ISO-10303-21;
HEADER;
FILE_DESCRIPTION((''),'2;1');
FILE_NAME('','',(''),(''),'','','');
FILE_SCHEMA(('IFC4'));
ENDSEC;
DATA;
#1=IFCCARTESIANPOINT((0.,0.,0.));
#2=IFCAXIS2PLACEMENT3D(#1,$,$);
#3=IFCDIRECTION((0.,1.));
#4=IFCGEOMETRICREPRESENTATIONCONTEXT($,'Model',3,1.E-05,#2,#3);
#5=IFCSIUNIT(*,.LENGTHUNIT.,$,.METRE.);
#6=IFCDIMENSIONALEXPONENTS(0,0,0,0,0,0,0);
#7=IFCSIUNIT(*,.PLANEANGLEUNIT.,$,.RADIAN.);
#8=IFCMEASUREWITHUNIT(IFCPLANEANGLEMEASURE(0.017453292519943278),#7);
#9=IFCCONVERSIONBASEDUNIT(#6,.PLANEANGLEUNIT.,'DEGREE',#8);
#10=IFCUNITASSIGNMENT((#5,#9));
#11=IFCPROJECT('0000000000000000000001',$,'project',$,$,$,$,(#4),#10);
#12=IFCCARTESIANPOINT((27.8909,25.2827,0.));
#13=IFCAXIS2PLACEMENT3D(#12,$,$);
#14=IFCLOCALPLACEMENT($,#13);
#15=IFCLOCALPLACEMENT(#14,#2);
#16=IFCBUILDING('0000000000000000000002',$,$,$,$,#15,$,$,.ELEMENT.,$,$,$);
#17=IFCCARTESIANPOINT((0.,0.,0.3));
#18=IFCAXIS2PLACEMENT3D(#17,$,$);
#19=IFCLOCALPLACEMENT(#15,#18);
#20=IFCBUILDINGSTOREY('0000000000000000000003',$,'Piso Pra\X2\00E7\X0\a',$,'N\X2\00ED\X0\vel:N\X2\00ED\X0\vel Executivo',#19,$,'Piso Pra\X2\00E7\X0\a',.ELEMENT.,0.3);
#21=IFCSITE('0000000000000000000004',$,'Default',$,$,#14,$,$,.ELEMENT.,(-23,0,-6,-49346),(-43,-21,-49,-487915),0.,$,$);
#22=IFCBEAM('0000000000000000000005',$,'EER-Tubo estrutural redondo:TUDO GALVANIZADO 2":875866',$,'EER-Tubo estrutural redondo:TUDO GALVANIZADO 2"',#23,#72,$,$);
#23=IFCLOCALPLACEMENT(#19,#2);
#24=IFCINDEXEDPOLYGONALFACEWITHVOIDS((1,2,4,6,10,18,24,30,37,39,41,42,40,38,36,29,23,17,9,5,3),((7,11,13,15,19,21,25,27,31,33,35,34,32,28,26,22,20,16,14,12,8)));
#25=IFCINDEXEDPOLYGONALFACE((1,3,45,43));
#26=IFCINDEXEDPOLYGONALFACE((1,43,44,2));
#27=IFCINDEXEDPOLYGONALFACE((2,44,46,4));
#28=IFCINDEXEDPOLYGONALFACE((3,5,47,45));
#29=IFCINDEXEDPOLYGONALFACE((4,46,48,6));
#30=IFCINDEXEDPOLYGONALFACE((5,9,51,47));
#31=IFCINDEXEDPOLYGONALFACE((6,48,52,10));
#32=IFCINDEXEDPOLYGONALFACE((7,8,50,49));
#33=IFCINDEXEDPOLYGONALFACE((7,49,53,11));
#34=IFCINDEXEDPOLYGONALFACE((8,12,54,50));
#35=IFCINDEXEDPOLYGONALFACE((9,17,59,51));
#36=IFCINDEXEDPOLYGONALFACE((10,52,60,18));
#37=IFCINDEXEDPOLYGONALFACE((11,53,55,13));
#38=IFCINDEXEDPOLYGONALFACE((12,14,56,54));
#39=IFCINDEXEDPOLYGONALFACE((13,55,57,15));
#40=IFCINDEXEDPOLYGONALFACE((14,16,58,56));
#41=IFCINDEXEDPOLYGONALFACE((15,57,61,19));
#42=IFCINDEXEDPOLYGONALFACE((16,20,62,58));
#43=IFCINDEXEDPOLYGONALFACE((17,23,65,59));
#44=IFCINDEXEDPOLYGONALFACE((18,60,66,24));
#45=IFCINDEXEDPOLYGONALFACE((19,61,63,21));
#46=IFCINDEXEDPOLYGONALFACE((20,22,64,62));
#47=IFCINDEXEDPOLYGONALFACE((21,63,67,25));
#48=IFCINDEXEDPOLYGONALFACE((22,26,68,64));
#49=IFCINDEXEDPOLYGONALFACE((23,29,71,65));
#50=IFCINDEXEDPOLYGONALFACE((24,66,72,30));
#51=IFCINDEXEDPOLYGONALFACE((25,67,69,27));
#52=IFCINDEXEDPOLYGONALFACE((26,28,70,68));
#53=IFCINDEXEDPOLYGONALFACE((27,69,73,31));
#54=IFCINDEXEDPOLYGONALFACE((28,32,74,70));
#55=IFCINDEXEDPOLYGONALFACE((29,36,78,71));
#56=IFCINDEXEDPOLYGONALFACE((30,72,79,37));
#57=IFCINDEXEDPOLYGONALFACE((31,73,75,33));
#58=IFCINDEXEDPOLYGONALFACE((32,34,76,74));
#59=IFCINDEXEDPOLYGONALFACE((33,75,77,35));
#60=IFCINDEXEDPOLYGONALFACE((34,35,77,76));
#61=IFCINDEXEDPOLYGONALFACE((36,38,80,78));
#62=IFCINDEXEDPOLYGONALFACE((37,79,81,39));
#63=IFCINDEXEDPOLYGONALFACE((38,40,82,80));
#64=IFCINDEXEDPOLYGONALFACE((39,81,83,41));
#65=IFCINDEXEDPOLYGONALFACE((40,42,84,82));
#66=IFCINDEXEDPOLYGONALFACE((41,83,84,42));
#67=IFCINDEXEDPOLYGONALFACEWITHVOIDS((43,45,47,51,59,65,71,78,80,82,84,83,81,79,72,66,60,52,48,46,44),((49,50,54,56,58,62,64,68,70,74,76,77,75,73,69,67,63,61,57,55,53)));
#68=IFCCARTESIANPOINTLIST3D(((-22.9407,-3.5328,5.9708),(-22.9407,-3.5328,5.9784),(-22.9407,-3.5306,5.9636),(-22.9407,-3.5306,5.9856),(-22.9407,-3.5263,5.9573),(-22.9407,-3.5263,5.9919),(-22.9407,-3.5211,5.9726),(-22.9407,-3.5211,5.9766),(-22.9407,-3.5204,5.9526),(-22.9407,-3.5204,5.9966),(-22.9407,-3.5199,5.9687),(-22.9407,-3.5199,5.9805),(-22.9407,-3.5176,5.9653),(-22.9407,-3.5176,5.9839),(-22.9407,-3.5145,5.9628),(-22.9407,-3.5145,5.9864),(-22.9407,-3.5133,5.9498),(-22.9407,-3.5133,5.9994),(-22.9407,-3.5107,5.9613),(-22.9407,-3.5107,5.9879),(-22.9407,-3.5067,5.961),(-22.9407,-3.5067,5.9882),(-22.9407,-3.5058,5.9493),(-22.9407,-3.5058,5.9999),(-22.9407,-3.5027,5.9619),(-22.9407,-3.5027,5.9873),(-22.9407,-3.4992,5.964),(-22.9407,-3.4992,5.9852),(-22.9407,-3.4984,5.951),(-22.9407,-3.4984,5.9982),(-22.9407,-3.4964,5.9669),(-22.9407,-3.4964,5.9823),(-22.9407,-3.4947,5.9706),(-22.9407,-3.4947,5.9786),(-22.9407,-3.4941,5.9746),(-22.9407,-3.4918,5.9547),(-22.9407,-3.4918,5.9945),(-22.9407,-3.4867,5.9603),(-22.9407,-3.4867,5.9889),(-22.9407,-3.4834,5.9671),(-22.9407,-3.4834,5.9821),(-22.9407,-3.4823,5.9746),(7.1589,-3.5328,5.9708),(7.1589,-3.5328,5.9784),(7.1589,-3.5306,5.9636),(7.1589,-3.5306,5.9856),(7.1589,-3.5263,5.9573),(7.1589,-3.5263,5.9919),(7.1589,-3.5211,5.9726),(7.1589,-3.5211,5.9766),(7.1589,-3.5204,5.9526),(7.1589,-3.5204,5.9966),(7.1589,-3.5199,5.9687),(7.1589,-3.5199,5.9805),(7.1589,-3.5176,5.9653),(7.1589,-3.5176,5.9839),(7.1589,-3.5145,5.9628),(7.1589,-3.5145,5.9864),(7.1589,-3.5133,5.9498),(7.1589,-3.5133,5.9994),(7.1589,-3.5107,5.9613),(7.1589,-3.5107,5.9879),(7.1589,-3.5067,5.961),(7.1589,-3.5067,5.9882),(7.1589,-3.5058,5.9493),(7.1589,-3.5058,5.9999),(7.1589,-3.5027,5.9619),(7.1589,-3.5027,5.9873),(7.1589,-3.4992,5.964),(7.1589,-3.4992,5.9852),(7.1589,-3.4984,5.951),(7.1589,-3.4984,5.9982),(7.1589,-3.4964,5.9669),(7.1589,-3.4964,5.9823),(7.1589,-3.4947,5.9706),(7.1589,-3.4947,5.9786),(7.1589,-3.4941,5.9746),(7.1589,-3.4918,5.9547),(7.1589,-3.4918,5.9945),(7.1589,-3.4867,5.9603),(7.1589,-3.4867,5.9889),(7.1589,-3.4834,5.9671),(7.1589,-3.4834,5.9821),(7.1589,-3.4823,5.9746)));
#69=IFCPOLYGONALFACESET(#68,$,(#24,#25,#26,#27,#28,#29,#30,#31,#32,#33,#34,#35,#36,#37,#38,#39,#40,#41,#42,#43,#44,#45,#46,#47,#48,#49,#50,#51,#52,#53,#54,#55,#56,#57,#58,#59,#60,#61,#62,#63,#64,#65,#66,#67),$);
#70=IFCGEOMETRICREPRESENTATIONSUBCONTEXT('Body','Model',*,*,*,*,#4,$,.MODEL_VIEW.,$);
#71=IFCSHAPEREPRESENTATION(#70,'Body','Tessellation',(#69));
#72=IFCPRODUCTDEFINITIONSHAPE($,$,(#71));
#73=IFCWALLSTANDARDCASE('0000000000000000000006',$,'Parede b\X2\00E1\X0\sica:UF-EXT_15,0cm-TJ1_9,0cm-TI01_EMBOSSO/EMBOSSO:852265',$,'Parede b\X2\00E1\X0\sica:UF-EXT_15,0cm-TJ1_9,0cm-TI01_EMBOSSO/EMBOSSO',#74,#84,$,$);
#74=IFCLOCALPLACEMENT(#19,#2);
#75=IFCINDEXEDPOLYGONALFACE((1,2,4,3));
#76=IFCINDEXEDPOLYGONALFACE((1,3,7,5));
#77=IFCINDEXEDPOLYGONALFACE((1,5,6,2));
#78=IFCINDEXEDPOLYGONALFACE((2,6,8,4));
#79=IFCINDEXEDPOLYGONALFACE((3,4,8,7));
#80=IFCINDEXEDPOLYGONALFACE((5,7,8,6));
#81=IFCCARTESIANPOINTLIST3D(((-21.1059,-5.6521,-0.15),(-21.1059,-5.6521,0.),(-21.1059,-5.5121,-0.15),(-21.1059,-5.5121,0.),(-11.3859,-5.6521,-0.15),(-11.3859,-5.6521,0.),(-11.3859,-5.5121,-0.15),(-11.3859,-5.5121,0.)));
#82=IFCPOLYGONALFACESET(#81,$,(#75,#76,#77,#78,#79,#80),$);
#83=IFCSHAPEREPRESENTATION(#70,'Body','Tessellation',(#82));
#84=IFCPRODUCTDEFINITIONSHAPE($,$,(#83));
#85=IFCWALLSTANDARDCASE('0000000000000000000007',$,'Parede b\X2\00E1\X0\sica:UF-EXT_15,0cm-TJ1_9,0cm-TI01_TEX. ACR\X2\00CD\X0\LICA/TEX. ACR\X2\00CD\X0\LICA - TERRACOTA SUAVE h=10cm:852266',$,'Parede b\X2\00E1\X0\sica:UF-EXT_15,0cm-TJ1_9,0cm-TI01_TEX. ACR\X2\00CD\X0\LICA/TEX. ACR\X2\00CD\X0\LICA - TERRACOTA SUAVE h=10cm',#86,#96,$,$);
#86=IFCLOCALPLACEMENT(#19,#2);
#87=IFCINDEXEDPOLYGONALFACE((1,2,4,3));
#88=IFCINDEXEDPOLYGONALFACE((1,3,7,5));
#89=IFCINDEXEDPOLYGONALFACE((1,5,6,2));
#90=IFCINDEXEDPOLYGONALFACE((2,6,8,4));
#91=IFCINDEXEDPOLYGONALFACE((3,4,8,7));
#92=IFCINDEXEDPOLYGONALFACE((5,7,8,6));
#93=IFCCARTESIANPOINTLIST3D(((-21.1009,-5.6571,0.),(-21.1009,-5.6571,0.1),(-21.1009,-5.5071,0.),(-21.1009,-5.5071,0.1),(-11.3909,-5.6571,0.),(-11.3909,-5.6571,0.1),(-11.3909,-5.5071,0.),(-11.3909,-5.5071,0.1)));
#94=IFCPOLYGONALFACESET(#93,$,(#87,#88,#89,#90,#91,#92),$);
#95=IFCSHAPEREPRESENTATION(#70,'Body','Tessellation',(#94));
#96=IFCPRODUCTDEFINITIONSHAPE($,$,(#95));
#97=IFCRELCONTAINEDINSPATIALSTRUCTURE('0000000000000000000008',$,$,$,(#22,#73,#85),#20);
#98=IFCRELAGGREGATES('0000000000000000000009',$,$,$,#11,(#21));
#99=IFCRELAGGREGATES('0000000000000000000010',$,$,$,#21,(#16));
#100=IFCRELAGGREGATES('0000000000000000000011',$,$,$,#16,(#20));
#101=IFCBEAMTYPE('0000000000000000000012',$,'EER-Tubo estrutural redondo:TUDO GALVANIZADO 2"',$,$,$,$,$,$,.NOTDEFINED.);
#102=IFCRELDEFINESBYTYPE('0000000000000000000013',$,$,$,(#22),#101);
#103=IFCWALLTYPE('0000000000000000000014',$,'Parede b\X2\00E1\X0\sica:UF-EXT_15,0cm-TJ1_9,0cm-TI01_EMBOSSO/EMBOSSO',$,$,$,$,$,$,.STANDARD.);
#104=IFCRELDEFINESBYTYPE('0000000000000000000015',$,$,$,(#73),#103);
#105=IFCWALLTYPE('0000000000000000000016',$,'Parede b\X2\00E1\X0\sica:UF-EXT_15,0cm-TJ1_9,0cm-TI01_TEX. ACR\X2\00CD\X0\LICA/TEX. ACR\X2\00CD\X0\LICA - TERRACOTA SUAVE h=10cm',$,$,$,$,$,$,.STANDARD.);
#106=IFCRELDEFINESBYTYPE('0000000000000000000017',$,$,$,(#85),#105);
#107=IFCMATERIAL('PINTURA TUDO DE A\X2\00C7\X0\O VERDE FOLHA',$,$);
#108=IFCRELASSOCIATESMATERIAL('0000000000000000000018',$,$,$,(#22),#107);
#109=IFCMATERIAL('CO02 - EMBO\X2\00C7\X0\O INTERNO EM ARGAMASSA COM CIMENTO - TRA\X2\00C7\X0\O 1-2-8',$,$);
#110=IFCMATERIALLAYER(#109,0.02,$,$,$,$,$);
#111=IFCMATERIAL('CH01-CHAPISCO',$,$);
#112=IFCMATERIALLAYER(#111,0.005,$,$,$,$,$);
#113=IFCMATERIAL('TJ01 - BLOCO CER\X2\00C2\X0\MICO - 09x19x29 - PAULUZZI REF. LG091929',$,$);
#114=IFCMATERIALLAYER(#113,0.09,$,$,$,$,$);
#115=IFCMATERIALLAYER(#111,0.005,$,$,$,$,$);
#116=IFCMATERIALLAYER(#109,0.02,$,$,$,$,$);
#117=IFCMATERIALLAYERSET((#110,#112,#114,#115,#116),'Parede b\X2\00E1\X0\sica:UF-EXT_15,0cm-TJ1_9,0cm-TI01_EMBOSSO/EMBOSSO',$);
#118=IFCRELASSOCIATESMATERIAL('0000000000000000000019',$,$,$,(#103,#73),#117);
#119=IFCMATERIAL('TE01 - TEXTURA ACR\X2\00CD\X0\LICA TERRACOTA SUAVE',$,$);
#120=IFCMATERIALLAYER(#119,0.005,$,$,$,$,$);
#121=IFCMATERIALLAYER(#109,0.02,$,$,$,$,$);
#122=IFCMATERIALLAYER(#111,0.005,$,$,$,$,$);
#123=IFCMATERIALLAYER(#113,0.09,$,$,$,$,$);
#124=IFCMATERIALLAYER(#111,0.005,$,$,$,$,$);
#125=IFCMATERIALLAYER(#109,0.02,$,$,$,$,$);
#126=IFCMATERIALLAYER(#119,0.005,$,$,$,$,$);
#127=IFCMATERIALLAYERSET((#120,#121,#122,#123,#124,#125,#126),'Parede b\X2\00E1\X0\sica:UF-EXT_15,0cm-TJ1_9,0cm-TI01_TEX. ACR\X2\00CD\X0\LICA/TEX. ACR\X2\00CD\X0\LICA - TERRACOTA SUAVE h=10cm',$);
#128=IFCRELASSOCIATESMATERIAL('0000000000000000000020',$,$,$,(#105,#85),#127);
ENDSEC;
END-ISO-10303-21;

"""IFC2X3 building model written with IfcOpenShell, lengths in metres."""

from ifc_helpers import new_model, entity, si_unit, converted_unit, direction, frame, frame_2d, origin, origin_2d_with_axis, place, context, subcontext, project, spatial, rectangle, hollow_circle, extrude, material, layer, layer_set, layer_usage, type_object, element, save


model = new_model("IFC2X3")

# Units and contexts
model_context = context("Model", 3, precision=1e-05, world=origin(), true_north=direction((0.0, 1.0)))
body_context = subcontext(model_context, "Body", "Model", "MODEL_VIEW")
ifc_project = project(units=[si_unit("LENGTHUNIT", "METRE"), converted_unit("PLANEANGLEUNIT", "DEGREE", entity("IfcPlaneAngleMeasure", 0.017453292519943278), si_unit("PLANEANGLEUNIT", "RADIAN"), dimensions=[0, 0, 0, 0, 0, 0, 0])], contexts=[model_context])

# Site, building, storey
site_placement = place(None, frame((27.8909, 25.2827, 0.0)))
site = spatial("IfcSite", under=ifc_project, at=site_placement, Name="Default", CompositionType="ELEMENT", RefLatitude=(-23, 0, -6, -49346), RefLongitude=(-43, -21, -49, -487915), RefElevation=0.0)
building_placement = place(site_placement, origin())
building = spatial("IfcBuilding", under=site, at=building_placement, CompositionType="ELEMENT")
storey_placement = place(building_placement, frame((0.0, 0.0, 0.3)))
storey = spatial("IfcBuildingStorey", under=building, at=storey_placement, Name="Piso Praça", ObjectType="Nível:Nível Executivo", LongName="Piso Praça", CompositionType="ELEMENT", Elevation=0.3)

# Beam
ifc_material_1 = material(Name="PINTURA TUDO DE AÇO VERDE FOLHA")
beam_type = type_object("IfcBeamType", Name="EER-Tubo estrutural redondo:TUDO GALVANIZADO 2\"", PredefinedType="NOTDEFINED")
beam_placement = place(storey_placement, frame((-22.9659, -3.5077, 0.0)))
element("IfcBeam", 1, at=beam_placement, inside=storey, type_object=beam_type, material=ifc_material_1, Name="EER-Tubo estrutural redondo:TUDO GALVANIZADO 2\":875866", ObjectType="EER-Tubo estrutural redondo:TUDO GALVANIZADO 2\"", context=body_context, shape_type="SweptSolid", body=[
    extrude(hollow_circle(Radius=0.0254, WallThickness=0.0118, at=origin_2d_with_axis()), frame((0.0252, 0.0, 5.9746), z_axis=(1.0, 0.0, 0.0), x_axis=(0.0, 1.0, 0.0)), (0.0, 0.0, 1.0), 30.0996),
])

# Walls
ifc_material_2 = material(Name="CO02 - EMBOÇO INTERNO EM ARGAMASSA COM CIMENTO - TRAÇO 1-2-8")
ifc_layer_1 = layer(ifc_material_2, 0.02)
ifc_material_3 = material(Name="CH01-CHAPISCO")
ifc_layer_2 = layer(ifc_material_3, 0.005)
ifc_material_4 = material(Name="TJ01 - BLOCO CERÂMICO - 09x19x29 - PAULUZZI REF. LG091929")
ifc_layer_3 = layer(ifc_material_4, 0.09)
ifc_layer_4 = layer(ifc_material_3, 0.005)
ifc_layer_5 = layer(ifc_material_2, 0.02)
ifc_layer_set_1 = layer_set([ifc_layer_1, ifc_layer_2, ifc_layer_3, ifc_layer_4, ifc_layer_5], Name="Parede básica:UF-EXT_15,0cm-TJ1_9,0cm-TI01_EMBOSSO/EMBOSSO")
ifc_layer_usage_1 = layer_usage(ifc_layer_set_1, "AXIS2", "NEGATIVE", 0.07)
wall_type_1 = type_object("IfcWallType", Name="Parede básica:UF-EXT_15,0cm-TJ1_9,0cm-TI01_EMBOSSO/EMBOSSO", PredefinedType="STANDARD", material=ifc_layer_set_1)
wall_1_placement = place(storey_placement, frame((-21.1059, -5.5821, -0.15)))
element("IfcWallStandardCase", 2, at=wall_1_placement, inside=storey, type_object=wall_type_1, material=ifc_layer_usage_1, Name="Parede básica:UF-EXT_15,0cm-TJ1_9,0cm-TI01_EMBOSSO/EMBOSSO:852265", ObjectType="Parede básica:UF-EXT_15,0cm-TJ1_9,0cm-TI01_EMBOSSO/EMBOSSO", context=body_context, shape_type="SweptSolid", body=[
    extrude(rectangle(XDim=9.72, YDim=0.14, at=frame_2d((4.86, 0.0), x_axis=(-1.0, 0.0))), origin(), (0.0, 0.0, 1.0), 0.15),
])
ifc_material_5 = material(Name="TE01 - TEXTURA ACRÍLICA TERRACOTA SUAVE")
ifc_layer_6 = layer(ifc_material_5, 0.005)
ifc_layer_7 = layer(ifc_material_2, 0.02)
ifc_layer_8 = layer(ifc_material_3, 0.005)
ifc_layer_9 = layer(ifc_material_4, 0.09)
ifc_layer_10 = layer(ifc_material_3, 0.005)
ifc_layer_11 = layer(ifc_material_2, 0.02)
ifc_layer_12 = layer(ifc_material_5, 0.005)
ifc_layer_set_2 = layer_set([ifc_layer_6, ifc_layer_7, ifc_layer_8, ifc_layer_9, ifc_layer_10, ifc_layer_11, ifc_layer_12], Name="Parede básica:UF-EXT_15,0cm-TJ1_9,0cm-TI01_TEX. ACRÍLICA/TEX. ACRÍLICA - TERRACOTA SUAVE h=10cm")
ifc_layer_usage_2 = layer_usage(ifc_layer_set_2, "AXIS2", "NEGATIVE", 0.075)
wall_type_2 = type_object("IfcWallType", Name="Parede básica:UF-EXT_15,0cm-TJ1_9,0cm-TI01_TEX. ACRÍLICA/TEX. ACRÍLICA - TERRACOTA SUAVE h=10cm", PredefinedType="STANDARD", material=ifc_layer_set_2)
wall_2_placement = place(storey_placement, frame((-21.1009, -5.5821, 0.0)))
element("IfcWallStandardCase", 3, at=wall_2_placement, inside=storey, type_object=wall_type_2, material=ifc_layer_usage_2, Name="Parede básica:UF-EXT_15,0cm-TJ1_9,0cm-TI01_TEX. ACRÍLICA/TEX. ACRÍLICA - TERRACOTA SUAVE h=10cm:852266", ObjectType="Parede básica:UF-EXT_15,0cm-TJ1_9,0cm-TI01_TEX. ACRÍLICA/TEX. ACRÍLICA - TERRACOTA SUAVE h=10cm", context=body_context, shape_type="SweptSolid", body=[
    extrude(rectangle(XDim=9.71, YDim=0.15, at=frame_2d((4.855, 0.0), x_axis=(-1.0, 0.0))), origin(), (0.0, 0.0, 1.0), 0.1),
])

save(model, "model.ifc")
